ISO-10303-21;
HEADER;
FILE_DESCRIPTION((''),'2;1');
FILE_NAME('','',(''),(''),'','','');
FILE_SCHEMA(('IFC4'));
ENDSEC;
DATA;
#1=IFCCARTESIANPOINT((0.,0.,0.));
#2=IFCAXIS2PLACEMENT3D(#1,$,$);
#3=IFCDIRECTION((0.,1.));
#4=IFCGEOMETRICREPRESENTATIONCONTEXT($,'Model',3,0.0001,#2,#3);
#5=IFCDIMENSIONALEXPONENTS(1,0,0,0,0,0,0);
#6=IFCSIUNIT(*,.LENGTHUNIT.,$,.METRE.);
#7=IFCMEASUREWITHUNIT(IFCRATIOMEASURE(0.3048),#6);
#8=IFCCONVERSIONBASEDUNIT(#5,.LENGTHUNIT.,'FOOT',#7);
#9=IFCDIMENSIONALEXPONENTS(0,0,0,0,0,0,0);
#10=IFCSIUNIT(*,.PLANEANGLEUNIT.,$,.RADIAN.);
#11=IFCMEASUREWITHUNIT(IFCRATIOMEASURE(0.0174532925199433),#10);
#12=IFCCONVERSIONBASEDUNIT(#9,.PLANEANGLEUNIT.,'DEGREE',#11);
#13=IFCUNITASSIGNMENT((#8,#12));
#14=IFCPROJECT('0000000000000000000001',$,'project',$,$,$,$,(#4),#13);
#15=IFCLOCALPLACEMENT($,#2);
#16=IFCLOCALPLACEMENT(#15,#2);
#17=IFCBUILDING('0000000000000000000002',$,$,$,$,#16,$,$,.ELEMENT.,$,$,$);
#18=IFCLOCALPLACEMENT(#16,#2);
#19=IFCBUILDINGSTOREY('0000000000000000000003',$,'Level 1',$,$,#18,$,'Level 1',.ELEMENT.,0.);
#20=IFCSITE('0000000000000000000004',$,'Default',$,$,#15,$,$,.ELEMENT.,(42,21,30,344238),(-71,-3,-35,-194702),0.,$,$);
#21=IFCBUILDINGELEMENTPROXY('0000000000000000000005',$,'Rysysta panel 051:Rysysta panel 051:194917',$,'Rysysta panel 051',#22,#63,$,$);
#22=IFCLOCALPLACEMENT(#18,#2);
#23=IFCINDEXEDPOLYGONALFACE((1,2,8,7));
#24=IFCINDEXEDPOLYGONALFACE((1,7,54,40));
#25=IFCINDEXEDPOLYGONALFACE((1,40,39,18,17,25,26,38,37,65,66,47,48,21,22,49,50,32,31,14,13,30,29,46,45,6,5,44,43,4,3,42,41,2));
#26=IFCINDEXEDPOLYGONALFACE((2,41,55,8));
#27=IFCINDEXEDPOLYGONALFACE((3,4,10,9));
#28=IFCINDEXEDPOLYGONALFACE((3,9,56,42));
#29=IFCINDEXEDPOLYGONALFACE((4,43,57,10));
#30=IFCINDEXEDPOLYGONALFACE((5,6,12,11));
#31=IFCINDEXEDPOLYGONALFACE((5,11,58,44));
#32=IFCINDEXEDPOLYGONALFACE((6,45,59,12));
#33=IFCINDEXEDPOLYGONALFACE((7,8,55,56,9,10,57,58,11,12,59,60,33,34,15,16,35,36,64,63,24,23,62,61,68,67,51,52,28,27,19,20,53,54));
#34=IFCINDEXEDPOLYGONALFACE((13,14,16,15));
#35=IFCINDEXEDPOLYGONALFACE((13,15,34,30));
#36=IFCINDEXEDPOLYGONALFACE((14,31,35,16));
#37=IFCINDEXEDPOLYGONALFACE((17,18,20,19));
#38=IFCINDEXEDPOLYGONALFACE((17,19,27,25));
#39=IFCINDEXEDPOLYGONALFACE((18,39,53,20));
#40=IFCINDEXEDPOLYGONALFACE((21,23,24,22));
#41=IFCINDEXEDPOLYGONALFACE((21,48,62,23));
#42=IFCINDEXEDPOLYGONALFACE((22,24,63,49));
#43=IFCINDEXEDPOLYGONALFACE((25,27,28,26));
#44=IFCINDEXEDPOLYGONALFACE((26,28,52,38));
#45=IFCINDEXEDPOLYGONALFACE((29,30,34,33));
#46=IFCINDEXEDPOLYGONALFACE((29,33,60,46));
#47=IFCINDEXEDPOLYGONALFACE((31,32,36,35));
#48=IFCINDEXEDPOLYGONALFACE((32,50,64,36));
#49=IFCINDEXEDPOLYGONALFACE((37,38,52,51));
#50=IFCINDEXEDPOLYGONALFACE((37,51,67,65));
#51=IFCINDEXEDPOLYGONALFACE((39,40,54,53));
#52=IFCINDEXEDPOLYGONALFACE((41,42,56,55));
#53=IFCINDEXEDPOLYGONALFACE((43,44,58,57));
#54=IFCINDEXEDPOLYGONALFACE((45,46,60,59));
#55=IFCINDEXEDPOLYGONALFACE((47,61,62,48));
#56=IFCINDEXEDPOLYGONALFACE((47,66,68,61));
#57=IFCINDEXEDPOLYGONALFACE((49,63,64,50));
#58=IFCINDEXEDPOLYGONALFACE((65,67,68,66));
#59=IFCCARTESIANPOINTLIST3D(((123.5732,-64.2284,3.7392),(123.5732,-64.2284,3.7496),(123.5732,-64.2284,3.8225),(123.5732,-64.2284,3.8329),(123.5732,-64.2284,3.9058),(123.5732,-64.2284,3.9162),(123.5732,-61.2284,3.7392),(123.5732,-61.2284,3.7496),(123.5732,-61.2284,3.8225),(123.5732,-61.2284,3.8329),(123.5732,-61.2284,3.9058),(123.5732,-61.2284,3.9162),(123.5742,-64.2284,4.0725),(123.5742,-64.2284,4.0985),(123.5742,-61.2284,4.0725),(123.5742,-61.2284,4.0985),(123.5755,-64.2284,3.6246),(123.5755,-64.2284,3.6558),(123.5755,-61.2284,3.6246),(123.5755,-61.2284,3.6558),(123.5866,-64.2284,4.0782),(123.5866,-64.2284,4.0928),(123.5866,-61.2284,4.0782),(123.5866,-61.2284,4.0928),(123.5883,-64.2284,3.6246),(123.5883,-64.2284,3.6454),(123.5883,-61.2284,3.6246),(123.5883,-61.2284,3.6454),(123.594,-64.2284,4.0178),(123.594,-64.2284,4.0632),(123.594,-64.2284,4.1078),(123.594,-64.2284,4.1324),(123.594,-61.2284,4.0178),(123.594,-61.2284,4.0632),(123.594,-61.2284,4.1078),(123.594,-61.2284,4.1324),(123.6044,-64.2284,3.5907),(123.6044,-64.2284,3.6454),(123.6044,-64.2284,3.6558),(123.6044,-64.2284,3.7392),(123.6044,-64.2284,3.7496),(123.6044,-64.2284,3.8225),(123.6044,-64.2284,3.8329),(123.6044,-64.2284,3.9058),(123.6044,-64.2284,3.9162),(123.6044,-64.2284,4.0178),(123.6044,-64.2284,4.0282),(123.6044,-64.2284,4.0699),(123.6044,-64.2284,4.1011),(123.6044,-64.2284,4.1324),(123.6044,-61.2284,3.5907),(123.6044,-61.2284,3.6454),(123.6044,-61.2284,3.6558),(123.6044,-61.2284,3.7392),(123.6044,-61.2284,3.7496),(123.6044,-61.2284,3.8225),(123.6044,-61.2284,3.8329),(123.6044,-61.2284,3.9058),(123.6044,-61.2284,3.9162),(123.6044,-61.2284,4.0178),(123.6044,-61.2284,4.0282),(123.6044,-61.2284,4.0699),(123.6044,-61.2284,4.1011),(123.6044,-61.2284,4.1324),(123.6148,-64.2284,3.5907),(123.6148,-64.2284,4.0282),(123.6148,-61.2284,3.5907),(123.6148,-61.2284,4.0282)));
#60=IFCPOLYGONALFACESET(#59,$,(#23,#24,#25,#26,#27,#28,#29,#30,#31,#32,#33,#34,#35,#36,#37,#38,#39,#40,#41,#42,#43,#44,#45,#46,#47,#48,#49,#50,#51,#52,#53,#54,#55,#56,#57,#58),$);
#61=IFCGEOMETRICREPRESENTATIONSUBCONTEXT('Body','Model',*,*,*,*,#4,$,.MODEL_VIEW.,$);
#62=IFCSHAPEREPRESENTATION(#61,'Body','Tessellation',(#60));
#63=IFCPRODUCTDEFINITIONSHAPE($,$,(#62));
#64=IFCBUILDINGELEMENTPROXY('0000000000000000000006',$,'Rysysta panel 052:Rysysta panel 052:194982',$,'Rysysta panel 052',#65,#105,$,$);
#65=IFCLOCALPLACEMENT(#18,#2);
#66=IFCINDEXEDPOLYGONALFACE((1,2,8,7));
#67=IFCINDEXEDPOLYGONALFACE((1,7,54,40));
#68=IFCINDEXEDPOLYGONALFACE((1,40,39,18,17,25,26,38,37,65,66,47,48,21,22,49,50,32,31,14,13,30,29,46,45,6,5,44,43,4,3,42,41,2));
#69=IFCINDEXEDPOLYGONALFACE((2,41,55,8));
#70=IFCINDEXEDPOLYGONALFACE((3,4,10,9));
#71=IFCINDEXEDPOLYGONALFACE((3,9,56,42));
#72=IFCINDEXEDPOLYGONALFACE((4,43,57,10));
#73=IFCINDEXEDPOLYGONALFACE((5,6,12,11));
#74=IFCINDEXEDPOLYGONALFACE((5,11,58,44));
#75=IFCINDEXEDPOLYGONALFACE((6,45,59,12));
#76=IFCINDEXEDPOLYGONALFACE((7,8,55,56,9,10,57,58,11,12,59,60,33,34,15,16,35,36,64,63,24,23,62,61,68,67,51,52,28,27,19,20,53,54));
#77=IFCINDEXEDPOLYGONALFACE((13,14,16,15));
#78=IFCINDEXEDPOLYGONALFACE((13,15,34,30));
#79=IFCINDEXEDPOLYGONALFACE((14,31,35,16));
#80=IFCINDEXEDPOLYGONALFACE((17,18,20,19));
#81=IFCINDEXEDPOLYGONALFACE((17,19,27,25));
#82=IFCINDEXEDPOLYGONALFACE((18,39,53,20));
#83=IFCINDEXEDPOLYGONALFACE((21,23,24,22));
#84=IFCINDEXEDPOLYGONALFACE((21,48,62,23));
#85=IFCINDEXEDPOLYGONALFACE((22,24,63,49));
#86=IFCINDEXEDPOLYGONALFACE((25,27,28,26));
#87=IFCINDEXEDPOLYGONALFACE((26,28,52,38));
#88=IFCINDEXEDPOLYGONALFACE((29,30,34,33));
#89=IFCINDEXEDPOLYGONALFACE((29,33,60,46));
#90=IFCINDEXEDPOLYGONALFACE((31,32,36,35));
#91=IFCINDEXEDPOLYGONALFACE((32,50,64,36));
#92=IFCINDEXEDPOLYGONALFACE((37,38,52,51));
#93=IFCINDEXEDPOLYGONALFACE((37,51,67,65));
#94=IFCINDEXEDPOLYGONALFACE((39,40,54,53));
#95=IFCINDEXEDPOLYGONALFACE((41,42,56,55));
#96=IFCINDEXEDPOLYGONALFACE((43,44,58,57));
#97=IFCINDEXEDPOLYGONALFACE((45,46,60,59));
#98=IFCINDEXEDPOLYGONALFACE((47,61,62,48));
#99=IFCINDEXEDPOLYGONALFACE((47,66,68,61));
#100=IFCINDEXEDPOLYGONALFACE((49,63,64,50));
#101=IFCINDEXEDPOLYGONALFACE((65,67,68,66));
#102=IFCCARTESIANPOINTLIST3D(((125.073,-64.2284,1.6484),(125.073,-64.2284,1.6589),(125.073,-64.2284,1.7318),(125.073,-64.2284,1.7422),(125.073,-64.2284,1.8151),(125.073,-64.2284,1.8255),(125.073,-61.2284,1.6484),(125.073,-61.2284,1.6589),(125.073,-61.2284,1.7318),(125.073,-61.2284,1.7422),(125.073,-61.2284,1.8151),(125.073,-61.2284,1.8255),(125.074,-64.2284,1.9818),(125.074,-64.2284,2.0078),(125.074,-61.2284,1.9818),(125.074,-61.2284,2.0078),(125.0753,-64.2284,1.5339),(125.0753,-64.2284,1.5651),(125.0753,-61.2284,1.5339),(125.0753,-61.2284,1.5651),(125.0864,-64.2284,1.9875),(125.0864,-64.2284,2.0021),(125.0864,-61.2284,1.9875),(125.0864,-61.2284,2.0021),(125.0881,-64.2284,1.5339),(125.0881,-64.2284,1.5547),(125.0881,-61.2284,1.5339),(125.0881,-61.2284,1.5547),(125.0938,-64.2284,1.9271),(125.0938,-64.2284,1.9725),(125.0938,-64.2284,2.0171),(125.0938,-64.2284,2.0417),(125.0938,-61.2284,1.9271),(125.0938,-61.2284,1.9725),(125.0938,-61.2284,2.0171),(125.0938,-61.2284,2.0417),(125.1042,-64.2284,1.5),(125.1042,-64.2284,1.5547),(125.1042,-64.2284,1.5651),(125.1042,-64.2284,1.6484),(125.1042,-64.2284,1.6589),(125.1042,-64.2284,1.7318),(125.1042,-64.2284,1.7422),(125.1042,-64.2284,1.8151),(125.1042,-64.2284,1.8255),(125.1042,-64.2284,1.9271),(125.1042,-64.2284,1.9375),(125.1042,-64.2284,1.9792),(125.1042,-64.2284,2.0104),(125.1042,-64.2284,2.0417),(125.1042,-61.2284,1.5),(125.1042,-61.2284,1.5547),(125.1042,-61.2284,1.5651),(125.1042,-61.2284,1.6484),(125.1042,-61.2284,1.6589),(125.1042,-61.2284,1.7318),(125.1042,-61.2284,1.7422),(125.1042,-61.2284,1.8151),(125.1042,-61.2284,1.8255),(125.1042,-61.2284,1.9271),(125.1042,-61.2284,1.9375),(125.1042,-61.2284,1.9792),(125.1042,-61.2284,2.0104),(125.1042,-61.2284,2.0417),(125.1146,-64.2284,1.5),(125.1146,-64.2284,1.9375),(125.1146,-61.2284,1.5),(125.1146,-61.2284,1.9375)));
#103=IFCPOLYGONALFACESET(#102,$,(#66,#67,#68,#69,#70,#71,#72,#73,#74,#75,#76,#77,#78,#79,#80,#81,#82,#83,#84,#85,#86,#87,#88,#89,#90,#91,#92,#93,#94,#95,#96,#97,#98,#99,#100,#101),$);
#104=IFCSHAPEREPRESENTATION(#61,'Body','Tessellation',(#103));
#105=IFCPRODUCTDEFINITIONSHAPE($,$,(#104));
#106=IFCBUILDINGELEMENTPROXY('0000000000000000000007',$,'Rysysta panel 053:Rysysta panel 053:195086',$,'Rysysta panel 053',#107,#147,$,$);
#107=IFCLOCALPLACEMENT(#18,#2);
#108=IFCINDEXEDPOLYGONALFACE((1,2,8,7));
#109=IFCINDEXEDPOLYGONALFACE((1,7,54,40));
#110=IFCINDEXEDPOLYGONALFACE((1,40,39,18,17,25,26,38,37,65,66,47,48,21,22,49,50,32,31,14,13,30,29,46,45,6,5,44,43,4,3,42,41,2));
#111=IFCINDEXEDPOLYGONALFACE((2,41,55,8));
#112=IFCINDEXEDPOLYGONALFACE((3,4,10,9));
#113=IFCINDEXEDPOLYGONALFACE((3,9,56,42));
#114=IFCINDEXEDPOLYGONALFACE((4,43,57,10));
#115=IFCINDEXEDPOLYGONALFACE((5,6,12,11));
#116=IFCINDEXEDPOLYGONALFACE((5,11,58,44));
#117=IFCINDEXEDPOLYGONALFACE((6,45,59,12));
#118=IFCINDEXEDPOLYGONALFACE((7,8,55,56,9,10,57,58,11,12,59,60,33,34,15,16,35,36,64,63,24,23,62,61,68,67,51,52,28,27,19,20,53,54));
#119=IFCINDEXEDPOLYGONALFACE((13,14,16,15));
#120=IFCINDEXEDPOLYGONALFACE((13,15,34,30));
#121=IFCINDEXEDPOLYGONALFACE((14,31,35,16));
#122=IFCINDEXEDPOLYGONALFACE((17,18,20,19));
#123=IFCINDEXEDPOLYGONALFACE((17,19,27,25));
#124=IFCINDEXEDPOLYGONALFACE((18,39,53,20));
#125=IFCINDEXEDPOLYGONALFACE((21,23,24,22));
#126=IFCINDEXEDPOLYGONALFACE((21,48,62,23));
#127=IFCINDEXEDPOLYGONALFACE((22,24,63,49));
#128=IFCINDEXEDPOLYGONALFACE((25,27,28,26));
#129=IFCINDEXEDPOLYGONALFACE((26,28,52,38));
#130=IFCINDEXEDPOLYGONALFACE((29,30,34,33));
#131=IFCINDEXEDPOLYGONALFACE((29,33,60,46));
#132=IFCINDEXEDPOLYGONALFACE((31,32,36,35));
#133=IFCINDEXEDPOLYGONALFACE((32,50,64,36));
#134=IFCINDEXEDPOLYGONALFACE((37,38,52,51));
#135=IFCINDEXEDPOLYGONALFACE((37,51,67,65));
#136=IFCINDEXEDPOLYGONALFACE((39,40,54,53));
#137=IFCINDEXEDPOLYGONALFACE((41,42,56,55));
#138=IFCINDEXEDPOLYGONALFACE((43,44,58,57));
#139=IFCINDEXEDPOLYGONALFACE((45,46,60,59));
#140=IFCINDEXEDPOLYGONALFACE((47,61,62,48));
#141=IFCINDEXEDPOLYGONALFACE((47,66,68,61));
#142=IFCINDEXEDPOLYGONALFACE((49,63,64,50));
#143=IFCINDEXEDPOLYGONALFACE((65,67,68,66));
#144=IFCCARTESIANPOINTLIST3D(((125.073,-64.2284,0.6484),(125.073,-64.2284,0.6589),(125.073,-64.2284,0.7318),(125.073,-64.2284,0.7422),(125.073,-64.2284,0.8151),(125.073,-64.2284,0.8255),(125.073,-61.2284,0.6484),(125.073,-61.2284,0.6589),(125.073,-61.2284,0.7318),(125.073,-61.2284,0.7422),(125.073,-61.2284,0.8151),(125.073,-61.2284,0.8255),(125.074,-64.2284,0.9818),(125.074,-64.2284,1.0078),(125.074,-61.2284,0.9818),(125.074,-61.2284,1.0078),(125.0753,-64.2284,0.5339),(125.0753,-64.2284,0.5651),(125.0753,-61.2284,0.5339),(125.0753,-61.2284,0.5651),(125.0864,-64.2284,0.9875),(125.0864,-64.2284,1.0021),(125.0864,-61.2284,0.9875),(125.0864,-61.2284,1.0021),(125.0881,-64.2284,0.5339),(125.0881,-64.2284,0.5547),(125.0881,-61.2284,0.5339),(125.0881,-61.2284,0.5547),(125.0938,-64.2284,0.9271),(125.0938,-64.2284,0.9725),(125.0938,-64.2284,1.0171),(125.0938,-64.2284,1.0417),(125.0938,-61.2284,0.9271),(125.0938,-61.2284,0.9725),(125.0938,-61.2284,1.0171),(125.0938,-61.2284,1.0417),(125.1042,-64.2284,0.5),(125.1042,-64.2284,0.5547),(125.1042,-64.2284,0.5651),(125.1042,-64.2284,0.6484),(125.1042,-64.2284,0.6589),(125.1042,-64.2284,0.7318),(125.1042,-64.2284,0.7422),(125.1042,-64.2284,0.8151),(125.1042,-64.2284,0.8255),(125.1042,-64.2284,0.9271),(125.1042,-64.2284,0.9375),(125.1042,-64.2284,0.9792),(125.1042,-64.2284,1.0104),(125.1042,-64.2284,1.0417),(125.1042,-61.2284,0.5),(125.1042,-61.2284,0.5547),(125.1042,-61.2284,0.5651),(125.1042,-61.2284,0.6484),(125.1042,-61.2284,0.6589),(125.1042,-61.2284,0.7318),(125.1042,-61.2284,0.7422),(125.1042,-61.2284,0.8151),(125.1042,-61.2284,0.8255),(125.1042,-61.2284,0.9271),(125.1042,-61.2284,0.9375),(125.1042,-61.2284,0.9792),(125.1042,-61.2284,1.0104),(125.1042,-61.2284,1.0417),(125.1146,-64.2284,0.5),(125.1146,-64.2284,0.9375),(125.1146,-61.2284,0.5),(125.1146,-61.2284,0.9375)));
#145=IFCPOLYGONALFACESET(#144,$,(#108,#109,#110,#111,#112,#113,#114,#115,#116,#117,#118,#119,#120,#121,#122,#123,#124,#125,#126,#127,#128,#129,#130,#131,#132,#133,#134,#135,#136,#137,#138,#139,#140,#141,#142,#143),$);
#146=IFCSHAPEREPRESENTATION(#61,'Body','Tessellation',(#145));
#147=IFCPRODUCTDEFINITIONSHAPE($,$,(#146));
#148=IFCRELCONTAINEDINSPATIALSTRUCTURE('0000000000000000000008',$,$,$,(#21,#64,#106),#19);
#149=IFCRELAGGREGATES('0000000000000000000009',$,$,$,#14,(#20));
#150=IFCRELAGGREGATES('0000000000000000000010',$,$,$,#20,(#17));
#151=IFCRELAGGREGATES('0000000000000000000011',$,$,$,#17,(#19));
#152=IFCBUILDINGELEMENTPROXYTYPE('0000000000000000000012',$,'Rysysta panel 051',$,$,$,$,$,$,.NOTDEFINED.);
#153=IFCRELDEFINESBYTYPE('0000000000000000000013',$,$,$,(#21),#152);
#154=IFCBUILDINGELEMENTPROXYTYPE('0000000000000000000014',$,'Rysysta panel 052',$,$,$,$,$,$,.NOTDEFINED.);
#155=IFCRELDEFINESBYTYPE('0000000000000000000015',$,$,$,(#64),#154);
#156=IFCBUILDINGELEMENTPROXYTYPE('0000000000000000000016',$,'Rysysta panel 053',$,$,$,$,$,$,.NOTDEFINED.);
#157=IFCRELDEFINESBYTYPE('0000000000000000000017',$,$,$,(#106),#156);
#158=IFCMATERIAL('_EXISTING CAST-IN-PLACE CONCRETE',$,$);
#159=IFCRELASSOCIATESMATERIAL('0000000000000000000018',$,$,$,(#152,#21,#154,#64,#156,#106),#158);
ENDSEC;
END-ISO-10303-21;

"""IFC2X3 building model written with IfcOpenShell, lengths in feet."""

from ifc_helpers import new_model, entity, si_unit, converted_unit, direction, frame, origin, place, context, subcontext, project, spatial, polyline, outline, extrude, source, transform, mapped, material, type_object, type_shapes, element, save


model = new_model("IFC2X3")

# Units and contexts
model_context = context("Model", 3, precision=0.0001, world=origin(), true_north=direction((0.0, 1.0)))
body_context = subcontext(model_context, "Body", "Model", "MODEL_VIEW")
ifc_project = project(units=[converted_unit("LENGTHUNIT", "FOOT", entity("IfcRatioMeasure", 0.3048), si_unit("LENGTHUNIT", "METRE"), dimensions=[1, 0, 0, 0, 0, 0, 0]), converted_unit("PLANEANGLEUNIT", "DEGREE", entity("IfcRatioMeasure", 0.0174532925199433), si_unit("PLANEANGLEUNIT", "RADIAN"), dimensions=[0, 0, 0, 0, 0, 0, 0])], contexts=[model_context])

# Site, building, storey
site_placement = place(None, origin())
site = spatial("IfcSite", under=ifc_project, at=site_placement, Name="Default", CompositionType="ELEMENT", RefLatitude=(42, 21, 30, 344238), RefLongitude=(-71, -3, -35, -194702), RefElevation=0.0)
building_placement = place(site_placement, origin())
building = spatial("IfcBuilding", under=site, at=building_placement, CompositionType="ELEMENT")
storey_placement = place(building_placement, origin())
storey = spatial("IfcBuildingStorey", under=building, at=storey_placement, Name="Level 1", LongName="Level 1", CompositionType="ELEMENT", Elevation=0.0)

# Building element proxies
ifc_material_1 = material(Name="_EXISTING CAST-IN-PLACE CONCRETE")
building_element_proxy_type_1 = type_object("IfcBuildingElementProxyType", Name="Rysysta panel 051", PredefinedType="NOTDEFINED", material=ifc_material_1)
shared_shape_1 = source(origin(), body_context, "Body", "SweptSolid", [
    extrude(outline(polyline([(-0.1457, -0.022), (0.2918, -0.022), (0.2918, -0.0116), (0.2371, -0.0116), (0.2371, 0.0045), (0.258, 0.0045), (0.258, 0.0173), (0.2267, 0.0173), (0.2267, -0.0116), (0.1434, -0.0116), (0.1434, 0.0196), (0.133, 0.0196), (0.133, -0.0116), (0.06, -0.0116), (0.06, 0.0196), (0.0496, 0.0196), (0.0496, -0.0116), (-0.0233, -0.0116), (-0.0233, 0.0196), (-0.0337, 0.0196), (-0.0337, -0.0116), (-0.1353, -0.0116), (-0.1353, -0.0012), (-0.1807, -0.0012), (-0.1899, 0.0186), (-0.216, 0.0186), (-0.2252, -0.0012), (-0.2498, -0.0012), (-0.2498, -0.0116), (-0.2186, -0.0116), (-0.2103, 0.0062), (-0.1956, 0.0062), (-0.1873, -0.0116), (-0.1457, -0.0116), (-0.1457, -0.022)])), frame((123.5928, -64.2284, 3.8825), z_axis=(0.0, 1.0, 0.0), x_axis=(0.0, 0.0, -1.0)), (0.0, 0.0, 1.0), 3.0),
])
type_shapes(building_element_proxy_type_1, [shared_shape_1])
proxy_1_placement = place(storey_placement, origin())
element("IfcBuildingElementProxy", 1, at=proxy_1_placement, inside=storey, type_object=building_element_proxy_type_1, material=ifc_material_1, Name="Rysysta panel 051:Rysysta panel 051:194917", ObjectType="Rysysta panel 051", context=body_context, shape_type="MappedRepresentation", body=[
    mapped(shared_shape_1, transform((0.0, 0.0, 0.0), scale=1.0)),
])
building_element_proxy_type_2 = type_object("IfcBuildingElementProxyType", Name="Rysysta panel 052", PredefinedType="NOTDEFINED", material=ifc_material_1)
shared_shape_2 = source(origin(), body_context, "Body", "SweptSolid", [
    extrude(outline(polyline([(-0.1457, -0.022), (0.2918, -0.022), (0.2918, -0.0116), (0.2371, -0.0116), (0.2371, 0.0045), (0.258, 0.0045), (0.258, 0.0173), (0.2267, 0.0173), (0.2267, -0.0116), (0.1434, -0.0116), (0.1434, 0.0196), (0.133, 0.0196), (0.133, -0.0116), (0.06, -0.0116), (0.06, 0.0196), (0.0496, 0.0196), (0.0496, -0.0116), (-0.0233, -0.0116), (-0.0233, 0.0196), (-0.0337, 0.0196), (-0.0337, -0.0116), (-0.1353, -0.0116), (-0.1353, -0.0012), (-0.1807, -0.0012), (-0.1899, 0.0186), (-0.216, 0.0186), (-0.2252, -0.0012), (-0.2498, -0.0012), (-0.2498, -0.0116), (-0.2186, -0.0116), (-0.2103, 0.0062), (-0.1956, 0.0062), (-0.1873, -0.0116), (-0.1457, -0.0116), (-0.1457, -0.022)])), frame((125.0926, -64.2284, 1.7918), z_axis=(0.0, 1.0, 0.0), x_axis=(0.0, 0.0, -1.0)), (0.0, 0.0, 1.0), 3.0),
])
type_shapes(building_element_proxy_type_2, [shared_shape_2])
proxy_2_placement = place(storey_placement, origin())
element("IfcBuildingElementProxy", 2, at=proxy_2_placement, inside=storey, type_object=building_element_proxy_type_2, material=ifc_material_1, Name="Rysysta panel 052:Rysysta panel 052:194982", ObjectType="Rysysta panel 052", context=body_context, shape_type="MappedRepresentation", body=[
    mapped(shared_shape_2, transform((0.0, 0.0, 0.0), scale=1.0)),
])
building_element_proxy_type_3 = type_object("IfcBuildingElementProxyType", Name="Rysysta panel 053", PredefinedType="NOTDEFINED", material=ifc_material_1)
shared_shape_3 = source(origin(), body_context, "Body", "SweptSolid", [
    extrude(outline(polyline([(-0.1457, -0.022), (0.2918, -0.022), (0.2918, -0.0116), (0.2371, -0.0116), (0.2371, 0.0045), (0.258, 0.0045), (0.258, 0.0173), (0.2267, 0.0173), (0.2267, -0.0116), (0.1434, -0.0116), (0.1434, 0.0196), (0.133, 0.0196), (0.133, -0.0116), (0.06, -0.0116), (0.06, 0.0196), (0.0496, 0.0196), (0.0496, -0.0116), (-0.0233, -0.0116), (-0.0233, 0.0196), (-0.0337, 0.0196), (-0.0337, -0.0116), (-0.1353, -0.0116), (-0.1353, -0.0012), (-0.1807, -0.0012), (-0.1899, 0.0186), (-0.216, 0.0186), (-0.2252, -0.0012), (-0.2498, -0.0012), (-0.2498, -0.0116), (-0.2186, -0.0116), (-0.2103, 0.0062), (-0.1956, 0.0062), (-0.1873, -0.0116), (-0.1457, -0.0116), (-0.1457, -0.022)])), frame((125.0926, -64.2284, 0.7918), z_axis=(0.0, 1.0, 0.0), x_axis=(0.0, 0.0, -1.0)), (0.0, 0.0, 1.0), 3.0),
])
type_shapes(building_element_proxy_type_3, [shared_shape_3])
proxy_3_placement = place(storey_placement, origin())
element("IfcBuildingElementProxy", 3, at=proxy_3_placement, inside=storey, type_object=building_element_proxy_type_3, material=ifc_material_1, Name="Rysysta panel 053:Rysysta panel 053:195086", ObjectType="Rysysta panel 053", context=body_context, shape_type="MappedRepresentation", body=[
    mapped(shared_shape_3, transform((0.0, 0.0, 0.0), scale=1.0)),
])

save(model, "model.ifc")
